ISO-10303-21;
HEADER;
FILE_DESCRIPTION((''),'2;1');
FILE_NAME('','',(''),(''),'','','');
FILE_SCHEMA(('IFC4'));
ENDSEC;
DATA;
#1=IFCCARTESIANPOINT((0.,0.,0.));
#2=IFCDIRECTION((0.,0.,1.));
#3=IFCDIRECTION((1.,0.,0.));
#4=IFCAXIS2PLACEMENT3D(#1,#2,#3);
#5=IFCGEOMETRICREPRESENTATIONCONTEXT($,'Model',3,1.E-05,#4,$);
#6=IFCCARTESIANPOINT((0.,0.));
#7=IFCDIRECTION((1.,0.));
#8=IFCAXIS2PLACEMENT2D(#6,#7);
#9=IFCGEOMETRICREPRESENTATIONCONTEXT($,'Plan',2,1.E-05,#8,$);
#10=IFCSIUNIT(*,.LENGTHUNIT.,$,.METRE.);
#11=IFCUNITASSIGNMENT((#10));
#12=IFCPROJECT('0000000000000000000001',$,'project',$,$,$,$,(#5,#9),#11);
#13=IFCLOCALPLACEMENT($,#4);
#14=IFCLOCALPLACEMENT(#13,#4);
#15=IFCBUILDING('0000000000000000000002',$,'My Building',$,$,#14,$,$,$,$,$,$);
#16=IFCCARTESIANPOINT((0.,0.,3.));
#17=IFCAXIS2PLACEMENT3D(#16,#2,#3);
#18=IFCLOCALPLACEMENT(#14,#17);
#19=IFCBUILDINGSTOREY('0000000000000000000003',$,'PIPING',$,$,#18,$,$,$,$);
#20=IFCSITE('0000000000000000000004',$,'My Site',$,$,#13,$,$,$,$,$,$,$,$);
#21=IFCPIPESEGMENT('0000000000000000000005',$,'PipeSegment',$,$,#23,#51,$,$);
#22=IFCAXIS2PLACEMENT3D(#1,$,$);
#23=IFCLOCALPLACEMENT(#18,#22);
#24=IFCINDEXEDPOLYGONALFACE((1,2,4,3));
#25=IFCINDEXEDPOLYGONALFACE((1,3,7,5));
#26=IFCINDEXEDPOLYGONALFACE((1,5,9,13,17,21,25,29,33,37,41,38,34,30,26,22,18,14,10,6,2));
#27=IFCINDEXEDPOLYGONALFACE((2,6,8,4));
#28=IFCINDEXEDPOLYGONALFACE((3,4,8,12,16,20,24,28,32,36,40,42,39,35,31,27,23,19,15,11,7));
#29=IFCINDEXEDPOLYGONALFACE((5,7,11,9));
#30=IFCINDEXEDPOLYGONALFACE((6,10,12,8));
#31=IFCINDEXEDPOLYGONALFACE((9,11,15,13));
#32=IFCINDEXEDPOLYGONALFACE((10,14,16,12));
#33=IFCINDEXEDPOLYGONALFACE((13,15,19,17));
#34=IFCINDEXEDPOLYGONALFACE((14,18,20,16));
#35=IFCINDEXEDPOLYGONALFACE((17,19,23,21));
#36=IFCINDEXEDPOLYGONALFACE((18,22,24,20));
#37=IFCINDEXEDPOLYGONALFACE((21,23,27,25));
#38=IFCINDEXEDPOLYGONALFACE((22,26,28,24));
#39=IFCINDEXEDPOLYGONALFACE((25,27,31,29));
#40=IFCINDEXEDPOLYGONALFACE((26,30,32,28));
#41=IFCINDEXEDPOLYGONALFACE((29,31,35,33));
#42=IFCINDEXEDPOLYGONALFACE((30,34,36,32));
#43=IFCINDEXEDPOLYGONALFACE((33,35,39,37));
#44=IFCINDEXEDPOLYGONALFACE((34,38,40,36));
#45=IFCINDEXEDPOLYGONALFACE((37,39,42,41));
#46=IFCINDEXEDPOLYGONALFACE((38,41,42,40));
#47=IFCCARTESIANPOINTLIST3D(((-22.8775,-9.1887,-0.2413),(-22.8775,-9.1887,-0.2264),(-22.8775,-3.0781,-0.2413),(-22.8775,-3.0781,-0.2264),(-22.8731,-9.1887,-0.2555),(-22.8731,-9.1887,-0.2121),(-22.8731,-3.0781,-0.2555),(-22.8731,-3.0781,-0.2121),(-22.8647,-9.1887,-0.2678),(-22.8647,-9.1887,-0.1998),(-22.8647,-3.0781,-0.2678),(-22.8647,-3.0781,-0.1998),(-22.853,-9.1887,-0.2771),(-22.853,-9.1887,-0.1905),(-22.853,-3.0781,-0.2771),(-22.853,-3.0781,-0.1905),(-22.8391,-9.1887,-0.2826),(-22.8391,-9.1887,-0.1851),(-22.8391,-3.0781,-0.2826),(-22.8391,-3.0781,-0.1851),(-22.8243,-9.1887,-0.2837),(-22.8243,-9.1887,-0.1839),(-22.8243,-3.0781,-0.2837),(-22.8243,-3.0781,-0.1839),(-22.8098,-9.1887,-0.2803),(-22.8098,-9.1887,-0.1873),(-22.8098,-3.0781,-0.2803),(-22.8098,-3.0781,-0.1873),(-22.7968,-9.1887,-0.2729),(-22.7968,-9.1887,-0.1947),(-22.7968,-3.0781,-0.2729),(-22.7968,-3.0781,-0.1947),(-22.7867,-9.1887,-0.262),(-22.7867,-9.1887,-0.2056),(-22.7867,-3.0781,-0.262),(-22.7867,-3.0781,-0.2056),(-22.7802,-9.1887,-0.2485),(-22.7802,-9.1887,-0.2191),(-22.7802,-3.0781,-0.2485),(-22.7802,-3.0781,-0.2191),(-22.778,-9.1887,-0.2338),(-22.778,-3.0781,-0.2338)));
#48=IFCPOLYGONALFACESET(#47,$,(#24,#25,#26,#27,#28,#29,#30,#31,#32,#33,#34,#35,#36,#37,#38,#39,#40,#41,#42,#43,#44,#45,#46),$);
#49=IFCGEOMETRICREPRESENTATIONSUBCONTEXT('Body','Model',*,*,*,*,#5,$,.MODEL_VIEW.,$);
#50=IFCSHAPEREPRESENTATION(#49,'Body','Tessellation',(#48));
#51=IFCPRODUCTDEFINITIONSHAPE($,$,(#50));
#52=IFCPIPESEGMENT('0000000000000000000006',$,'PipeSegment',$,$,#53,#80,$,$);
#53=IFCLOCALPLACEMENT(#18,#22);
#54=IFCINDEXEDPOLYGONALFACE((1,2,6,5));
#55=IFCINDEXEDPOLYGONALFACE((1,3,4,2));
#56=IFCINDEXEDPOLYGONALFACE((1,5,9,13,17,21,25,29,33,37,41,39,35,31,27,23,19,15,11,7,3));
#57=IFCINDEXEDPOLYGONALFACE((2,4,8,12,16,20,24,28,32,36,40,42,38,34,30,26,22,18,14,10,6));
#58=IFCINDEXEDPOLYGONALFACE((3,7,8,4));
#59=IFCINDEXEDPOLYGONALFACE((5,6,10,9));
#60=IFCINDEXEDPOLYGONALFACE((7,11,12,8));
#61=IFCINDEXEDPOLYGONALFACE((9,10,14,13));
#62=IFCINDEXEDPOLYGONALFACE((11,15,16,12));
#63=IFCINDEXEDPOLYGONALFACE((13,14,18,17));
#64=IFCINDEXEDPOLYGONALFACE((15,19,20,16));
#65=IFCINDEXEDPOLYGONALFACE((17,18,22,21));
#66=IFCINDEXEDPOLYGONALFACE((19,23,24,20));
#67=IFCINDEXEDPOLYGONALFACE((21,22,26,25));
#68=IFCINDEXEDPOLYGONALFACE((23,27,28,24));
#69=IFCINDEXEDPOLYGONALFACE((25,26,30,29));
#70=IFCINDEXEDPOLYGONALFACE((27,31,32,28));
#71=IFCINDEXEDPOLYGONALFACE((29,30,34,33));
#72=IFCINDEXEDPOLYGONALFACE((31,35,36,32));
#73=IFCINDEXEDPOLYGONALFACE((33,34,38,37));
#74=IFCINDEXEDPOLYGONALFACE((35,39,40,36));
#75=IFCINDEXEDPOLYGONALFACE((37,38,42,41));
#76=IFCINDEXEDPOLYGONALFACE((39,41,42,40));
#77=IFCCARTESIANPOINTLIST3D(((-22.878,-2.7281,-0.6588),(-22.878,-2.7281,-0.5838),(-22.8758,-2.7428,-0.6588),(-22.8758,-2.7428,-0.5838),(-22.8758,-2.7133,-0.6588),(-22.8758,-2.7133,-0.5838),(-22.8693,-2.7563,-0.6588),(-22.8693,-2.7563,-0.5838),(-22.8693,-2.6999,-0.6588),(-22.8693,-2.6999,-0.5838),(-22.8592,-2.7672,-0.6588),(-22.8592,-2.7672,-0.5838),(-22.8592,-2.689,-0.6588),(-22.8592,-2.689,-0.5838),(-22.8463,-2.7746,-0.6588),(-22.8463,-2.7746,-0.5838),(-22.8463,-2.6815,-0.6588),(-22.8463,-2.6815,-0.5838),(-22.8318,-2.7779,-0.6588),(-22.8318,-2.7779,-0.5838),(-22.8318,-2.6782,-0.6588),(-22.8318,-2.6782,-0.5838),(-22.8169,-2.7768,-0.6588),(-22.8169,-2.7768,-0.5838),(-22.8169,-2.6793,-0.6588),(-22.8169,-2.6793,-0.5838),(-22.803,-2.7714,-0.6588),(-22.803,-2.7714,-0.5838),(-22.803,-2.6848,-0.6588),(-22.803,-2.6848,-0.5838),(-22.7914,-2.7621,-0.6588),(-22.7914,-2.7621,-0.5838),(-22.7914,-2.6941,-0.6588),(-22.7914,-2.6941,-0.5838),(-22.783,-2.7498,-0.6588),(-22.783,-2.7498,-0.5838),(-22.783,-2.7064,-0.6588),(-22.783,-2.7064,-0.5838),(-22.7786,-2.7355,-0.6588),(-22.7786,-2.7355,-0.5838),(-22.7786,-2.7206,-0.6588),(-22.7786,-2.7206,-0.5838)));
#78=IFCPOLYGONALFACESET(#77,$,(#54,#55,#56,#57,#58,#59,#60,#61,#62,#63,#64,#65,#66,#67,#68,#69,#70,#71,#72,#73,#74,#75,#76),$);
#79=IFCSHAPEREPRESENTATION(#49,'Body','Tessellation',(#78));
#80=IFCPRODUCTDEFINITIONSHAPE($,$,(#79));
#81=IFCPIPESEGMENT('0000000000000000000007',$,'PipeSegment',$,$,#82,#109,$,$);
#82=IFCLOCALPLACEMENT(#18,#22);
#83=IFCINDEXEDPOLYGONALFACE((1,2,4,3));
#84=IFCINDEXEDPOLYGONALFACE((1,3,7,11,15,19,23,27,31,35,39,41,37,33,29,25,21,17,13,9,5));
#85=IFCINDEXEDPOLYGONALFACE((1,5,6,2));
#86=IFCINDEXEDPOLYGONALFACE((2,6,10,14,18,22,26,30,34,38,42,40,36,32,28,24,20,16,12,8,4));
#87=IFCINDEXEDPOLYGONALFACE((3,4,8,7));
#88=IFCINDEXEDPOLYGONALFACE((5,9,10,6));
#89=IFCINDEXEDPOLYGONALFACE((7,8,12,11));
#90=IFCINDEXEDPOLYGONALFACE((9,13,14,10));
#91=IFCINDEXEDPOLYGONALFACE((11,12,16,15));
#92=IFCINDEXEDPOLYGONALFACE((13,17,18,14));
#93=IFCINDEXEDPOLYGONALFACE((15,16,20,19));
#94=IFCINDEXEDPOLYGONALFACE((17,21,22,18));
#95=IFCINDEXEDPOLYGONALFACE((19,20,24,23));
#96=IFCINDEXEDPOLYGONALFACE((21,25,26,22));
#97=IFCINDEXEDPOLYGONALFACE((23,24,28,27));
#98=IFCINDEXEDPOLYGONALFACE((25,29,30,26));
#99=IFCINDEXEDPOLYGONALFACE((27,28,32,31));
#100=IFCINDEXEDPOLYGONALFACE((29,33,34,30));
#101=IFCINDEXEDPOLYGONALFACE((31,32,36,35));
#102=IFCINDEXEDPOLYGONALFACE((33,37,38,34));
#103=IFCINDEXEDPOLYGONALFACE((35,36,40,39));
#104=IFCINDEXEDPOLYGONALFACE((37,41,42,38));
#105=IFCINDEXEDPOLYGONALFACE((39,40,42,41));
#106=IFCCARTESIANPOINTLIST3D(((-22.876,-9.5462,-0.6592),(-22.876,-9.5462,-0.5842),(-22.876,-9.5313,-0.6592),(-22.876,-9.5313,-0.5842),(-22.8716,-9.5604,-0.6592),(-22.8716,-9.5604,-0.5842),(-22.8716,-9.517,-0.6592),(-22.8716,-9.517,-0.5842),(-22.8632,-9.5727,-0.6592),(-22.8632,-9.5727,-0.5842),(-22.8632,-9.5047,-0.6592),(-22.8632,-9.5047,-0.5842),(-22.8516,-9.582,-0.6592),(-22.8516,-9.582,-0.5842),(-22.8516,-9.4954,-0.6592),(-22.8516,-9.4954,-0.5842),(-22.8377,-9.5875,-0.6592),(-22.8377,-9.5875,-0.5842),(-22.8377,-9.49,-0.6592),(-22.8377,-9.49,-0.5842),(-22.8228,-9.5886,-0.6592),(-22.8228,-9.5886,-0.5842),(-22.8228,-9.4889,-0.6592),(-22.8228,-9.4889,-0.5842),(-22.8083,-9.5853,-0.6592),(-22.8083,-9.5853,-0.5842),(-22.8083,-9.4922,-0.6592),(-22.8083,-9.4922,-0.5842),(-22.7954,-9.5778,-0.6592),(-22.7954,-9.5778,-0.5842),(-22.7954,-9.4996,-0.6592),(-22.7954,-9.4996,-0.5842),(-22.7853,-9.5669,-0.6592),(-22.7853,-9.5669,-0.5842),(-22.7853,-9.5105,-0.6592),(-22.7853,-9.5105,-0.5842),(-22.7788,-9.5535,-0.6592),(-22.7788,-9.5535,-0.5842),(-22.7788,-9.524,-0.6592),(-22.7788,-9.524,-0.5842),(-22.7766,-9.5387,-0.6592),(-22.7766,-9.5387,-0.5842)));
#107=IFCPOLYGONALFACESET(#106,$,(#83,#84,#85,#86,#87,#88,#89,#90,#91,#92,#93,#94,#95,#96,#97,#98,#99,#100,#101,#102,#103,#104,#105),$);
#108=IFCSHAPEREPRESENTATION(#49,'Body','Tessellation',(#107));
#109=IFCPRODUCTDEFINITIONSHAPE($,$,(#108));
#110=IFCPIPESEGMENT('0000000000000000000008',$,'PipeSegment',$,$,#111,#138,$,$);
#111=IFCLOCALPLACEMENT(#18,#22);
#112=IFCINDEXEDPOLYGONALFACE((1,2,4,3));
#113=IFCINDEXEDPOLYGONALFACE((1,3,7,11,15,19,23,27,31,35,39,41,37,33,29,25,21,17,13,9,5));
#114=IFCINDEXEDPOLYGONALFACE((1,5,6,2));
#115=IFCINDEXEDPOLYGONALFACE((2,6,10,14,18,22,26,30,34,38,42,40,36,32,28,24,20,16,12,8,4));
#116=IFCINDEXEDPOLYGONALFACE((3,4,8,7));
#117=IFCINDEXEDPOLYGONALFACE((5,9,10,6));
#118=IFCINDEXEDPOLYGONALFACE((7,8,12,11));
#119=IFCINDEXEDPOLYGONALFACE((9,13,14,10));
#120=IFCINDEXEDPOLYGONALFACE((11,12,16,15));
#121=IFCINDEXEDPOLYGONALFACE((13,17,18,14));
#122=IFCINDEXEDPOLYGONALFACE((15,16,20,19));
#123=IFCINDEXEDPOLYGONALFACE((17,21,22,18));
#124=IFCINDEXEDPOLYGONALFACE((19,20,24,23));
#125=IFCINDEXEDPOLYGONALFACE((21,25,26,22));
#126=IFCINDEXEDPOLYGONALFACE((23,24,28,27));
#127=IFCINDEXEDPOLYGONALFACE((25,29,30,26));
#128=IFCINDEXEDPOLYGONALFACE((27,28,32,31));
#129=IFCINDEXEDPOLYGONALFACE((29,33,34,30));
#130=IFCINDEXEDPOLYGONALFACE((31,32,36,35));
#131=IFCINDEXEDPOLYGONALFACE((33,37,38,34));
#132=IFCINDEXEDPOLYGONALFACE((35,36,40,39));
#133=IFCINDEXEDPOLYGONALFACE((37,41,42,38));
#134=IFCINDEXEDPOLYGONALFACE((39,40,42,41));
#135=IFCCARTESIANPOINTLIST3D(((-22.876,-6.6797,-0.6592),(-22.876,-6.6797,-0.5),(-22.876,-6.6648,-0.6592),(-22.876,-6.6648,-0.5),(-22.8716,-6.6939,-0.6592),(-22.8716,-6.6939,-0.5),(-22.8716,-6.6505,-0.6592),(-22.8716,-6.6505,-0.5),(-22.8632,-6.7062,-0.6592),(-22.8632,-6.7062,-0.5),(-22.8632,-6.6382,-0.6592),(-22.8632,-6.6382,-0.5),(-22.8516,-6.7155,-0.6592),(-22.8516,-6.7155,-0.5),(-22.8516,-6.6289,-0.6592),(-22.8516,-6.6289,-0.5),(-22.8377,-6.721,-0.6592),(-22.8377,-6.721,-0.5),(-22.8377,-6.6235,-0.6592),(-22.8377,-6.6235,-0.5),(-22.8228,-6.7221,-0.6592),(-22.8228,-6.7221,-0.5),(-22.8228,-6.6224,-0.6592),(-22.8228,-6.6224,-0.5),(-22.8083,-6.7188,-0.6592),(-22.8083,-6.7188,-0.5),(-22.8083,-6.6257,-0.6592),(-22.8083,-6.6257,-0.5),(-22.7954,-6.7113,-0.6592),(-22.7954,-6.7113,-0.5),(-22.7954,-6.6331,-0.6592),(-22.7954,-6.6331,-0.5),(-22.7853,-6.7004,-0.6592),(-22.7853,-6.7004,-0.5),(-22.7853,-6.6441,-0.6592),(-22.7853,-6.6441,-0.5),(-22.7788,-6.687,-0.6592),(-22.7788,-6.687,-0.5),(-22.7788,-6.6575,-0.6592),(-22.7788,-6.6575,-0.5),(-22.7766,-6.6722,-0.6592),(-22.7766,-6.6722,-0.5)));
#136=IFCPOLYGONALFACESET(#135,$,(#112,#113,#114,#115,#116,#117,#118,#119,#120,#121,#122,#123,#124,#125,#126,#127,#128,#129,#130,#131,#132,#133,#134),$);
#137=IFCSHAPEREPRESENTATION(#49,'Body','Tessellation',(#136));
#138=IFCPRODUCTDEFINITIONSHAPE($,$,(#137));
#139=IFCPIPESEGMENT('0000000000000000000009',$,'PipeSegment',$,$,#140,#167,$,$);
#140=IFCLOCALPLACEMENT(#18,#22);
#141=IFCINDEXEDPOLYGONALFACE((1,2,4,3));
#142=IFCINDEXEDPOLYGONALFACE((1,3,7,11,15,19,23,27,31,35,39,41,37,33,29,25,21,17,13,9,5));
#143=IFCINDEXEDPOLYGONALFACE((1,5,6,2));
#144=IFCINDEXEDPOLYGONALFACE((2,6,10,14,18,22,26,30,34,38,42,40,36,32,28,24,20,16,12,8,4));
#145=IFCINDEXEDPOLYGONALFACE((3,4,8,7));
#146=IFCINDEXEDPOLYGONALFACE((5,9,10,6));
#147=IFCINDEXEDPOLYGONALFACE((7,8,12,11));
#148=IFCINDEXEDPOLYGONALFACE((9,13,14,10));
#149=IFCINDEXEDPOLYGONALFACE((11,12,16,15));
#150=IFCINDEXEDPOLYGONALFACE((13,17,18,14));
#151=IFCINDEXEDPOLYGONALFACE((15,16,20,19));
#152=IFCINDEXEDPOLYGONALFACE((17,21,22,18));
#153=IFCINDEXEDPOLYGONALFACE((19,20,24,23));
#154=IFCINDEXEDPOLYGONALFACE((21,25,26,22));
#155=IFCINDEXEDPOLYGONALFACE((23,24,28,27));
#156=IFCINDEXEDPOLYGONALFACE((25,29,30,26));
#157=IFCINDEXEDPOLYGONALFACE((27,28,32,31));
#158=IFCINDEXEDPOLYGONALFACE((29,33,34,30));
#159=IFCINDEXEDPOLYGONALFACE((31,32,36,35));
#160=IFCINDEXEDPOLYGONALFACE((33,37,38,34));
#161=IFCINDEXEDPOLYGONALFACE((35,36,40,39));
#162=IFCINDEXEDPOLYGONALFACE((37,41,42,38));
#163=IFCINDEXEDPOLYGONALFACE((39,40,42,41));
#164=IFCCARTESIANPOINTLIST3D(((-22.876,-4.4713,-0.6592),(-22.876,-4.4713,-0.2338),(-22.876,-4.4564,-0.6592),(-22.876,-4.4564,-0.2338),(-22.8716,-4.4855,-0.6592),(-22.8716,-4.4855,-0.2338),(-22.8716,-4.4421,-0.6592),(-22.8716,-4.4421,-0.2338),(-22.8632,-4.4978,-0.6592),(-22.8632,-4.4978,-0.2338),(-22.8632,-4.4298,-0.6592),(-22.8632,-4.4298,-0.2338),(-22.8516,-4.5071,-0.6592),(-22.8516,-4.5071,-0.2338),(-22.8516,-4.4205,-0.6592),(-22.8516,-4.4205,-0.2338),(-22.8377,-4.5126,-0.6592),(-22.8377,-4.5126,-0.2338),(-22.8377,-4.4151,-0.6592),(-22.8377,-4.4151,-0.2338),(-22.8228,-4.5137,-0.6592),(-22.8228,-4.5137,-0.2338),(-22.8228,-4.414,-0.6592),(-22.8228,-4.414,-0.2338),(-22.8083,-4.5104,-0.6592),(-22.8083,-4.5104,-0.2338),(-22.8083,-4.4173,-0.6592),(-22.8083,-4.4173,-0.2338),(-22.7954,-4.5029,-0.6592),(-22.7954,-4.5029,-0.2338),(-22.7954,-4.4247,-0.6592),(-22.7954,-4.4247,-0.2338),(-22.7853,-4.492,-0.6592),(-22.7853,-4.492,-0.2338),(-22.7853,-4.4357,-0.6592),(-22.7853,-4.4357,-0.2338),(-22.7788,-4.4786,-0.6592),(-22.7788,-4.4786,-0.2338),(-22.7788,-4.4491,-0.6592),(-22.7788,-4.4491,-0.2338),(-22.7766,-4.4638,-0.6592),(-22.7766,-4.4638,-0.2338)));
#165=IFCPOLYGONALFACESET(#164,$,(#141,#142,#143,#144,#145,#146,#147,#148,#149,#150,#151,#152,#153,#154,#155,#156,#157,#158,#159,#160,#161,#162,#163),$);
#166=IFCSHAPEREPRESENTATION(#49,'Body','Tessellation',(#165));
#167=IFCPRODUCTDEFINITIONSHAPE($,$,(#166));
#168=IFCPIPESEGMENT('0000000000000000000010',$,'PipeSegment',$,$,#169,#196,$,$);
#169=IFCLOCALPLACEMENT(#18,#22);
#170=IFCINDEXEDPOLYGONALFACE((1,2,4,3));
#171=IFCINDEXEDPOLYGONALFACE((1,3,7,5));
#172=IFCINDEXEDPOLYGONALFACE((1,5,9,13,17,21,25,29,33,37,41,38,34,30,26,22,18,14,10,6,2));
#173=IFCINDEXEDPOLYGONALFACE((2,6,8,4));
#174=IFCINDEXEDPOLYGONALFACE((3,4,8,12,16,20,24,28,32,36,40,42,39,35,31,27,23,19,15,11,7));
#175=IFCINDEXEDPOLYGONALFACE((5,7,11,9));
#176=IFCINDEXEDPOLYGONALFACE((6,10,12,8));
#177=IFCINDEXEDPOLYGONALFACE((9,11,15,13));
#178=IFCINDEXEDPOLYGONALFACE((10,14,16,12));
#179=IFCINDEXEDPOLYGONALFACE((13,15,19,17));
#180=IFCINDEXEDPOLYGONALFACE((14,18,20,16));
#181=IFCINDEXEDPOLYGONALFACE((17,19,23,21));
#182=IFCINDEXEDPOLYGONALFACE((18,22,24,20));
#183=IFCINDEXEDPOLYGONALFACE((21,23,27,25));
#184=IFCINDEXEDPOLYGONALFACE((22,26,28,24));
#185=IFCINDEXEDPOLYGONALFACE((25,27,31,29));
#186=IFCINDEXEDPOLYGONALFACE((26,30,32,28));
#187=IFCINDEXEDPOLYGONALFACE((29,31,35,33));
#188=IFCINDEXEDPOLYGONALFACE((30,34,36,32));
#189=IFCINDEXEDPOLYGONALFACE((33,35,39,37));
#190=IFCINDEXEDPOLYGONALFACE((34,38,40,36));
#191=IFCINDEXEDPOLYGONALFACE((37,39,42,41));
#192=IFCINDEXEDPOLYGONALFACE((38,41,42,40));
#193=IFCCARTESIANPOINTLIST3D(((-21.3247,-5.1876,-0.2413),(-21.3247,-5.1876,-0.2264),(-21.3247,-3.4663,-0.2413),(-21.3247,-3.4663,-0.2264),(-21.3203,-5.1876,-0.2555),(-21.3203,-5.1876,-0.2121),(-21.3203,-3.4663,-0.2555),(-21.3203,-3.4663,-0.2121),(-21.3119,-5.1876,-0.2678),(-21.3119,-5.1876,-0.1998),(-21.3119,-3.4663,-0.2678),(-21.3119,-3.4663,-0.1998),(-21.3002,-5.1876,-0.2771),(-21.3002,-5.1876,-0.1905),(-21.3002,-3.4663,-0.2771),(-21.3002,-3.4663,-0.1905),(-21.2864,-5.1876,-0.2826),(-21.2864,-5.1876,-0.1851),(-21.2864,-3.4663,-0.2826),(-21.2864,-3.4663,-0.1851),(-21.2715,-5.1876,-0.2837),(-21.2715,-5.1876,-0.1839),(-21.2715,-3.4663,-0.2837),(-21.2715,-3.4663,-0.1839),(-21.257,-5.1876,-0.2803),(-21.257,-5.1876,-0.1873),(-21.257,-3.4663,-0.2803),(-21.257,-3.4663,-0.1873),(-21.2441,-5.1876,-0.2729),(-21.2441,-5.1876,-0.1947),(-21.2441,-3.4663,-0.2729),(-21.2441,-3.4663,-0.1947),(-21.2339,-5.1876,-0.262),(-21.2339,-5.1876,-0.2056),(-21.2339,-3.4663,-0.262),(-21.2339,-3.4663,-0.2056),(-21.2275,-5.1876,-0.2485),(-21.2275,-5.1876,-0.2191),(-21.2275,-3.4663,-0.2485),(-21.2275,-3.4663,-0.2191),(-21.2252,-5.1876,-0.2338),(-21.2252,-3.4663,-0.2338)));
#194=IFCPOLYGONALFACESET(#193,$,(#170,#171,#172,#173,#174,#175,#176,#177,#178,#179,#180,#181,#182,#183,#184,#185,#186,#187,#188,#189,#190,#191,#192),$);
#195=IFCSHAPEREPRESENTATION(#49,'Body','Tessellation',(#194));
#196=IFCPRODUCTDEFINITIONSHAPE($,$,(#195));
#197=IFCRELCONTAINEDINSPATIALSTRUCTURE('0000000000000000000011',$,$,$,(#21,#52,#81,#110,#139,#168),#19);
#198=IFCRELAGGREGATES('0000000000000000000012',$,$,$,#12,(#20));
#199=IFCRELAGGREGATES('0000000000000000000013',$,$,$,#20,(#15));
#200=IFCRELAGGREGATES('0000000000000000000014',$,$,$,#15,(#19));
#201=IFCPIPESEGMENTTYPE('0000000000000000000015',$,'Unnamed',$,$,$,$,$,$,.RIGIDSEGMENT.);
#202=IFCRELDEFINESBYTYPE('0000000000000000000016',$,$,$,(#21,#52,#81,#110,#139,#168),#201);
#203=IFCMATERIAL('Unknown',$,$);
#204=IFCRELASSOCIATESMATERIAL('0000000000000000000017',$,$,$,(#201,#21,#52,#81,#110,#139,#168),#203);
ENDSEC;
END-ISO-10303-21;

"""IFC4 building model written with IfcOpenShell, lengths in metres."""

from ifc_helpers import new_model, si_unit, frame, origin_with_axes, origin_2d_with_axis, place, context, subcontext, project, spatial, circle, extrude, material, material_profile, profile_set, profile_usage, type_object, element, save


model = new_model("IFC4")

# Units and contexts
model_context = context("Model", 3, precision=1e-05, world=origin_with_axes())
plan_context = context("Plan", 2, precision=1e-05, world=origin_2d_with_axis())
body_context = subcontext(model_context, "Body", "Model", "MODEL_VIEW")
ifc_project = project(units=[si_unit("LENGTHUNIT", "METRE")], contexts=[model_context, plan_context])

# Site, building, storey
site_placement = place(None, origin_with_axes())
site = spatial("IfcSite", under=ifc_project, at=site_placement, Name="My Site")
building_placement = place(site_placement, origin_with_axes())
building = spatial("IfcBuilding", under=site, at=building_placement, Name="My Building")
storey_placement = place(building_placement, frame((0.0, 0.0, 3.0), z_axis=(0.0, 0.0, 1.0), x_axis=(1.0, 0.0, 0.0)))
storey = spatial("IfcBuildingStorey", under=building, at=storey_placement, Name="PIPING")

# Pipe segments
ifc_material = material(Name="Unknown")
ifc_material_profile = material_profile(ifc_material, circle(Radius=0.05))
ifc_profile_set = profile_set([ifc_material_profile])
ifc_profile_usage_1 = profile_usage(ifc_profile_set, cardinal=5)
pipe_segment_type = type_object("IfcPipeSegmentType", Name="Unnamed", PredefinedType="RIGIDSEGMENT", material=ifc_profile_set)
pipe_segment_1_placement = place(storey_placement, frame((-22.828, -3.0781, -0.2338), z_axis=(0.0, -1.0, 0.0), x_axis=(1.0, 0.0, 0.0)))
element("IfcPipeSegment", 1, at=pipe_segment_1_placement, inside=storey, type_object=pipe_segment_type, material=ifc_profile_usage_1, Name="PipeSegment", context=body_context, shape_type="SweptSolid", body=[
    extrude(circle(Radius=0.05), origin_with_axes(), (0.0, 0.0, 1.0), 6.1106),
])
ifc_profile_usage_2 = profile_usage(ifc_profile_set, cardinal=5)
pipe_segment_2_placement = place(storey_placement, frame((-22.828, -2.7281, -0.5838), z_axis=(0.0, 0.0, -1.0), x_axis=(-1.0, 0.0, 0.0)))
element("IfcPipeSegment", 2, at=pipe_segment_2_placement, inside=storey, type_object=pipe_segment_type, material=ifc_profile_usage_2, Name="PipeSegment", context=body_context, shape_type="SweptSolid", body=[
    extrude(circle(Radius=0.05), origin_with_axes(), (0.0, 0.0, 1.0), 0.075),
])
ifc_profile_usage_3 = profile_usage(ifc_profile_set, cardinal=5)
pipe_segment_3_placement = place(storey_placement, frame((-22.8266, -9.5387, -0.5842), z_axis=(0.0, 0.0, -1.0), x_axis=(1.0, 0.0, 0.0)))
element("IfcPipeSegment", 3, at=pipe_segment_3_placement, inside=storey, type_object=pipe_segment_type, material=ifc_profile_usage_3, Name="PipeSegment", context=body_context, shape_type="SweptSolid", body=[
    extrude(circle(Radius=0.05), origin_with_axes(), (0.0, 0.0, 1.0), 0.075),
])
ifc_profile_usage_4 = profile_usage(ifc_profile_set, cardinal=5)
pipe_segment_4_placement = place(storey_placement, frame((-22.8266, -6.6722, -0.5), z_axis=(0.0, 0.0, -1.0), x_axis=(1.0, 0.0, 0.0)))
element("IfcPipeSegment", 4, at=pipe_segment_4_placement, inside=storey, type_object=pipe_segment_type, material=ifc_profile_usage_4, Name="PipeSegment", context=body_context, shape_type="SweptSolid", body=[
    extrude(circle(Radius=0.05), origin_with_axes(), (0.0, 0.0, 1.0), 0.1592),
])
ifc_profile_usage_5 = profile_usage(ifc_profile_set, cardinal=5)
pipe_segment_5_placement = place(storey_placement, frame((-22.8266, -4.4638, -0.2338), z_axis=(0.0, 0.0, -1.0), x_axis=(1.0, 0.0, 0.0)))
element("IfcPipeSegment", 5, at=pipe_segment_5_placement, inside=storey, type_object=pipe_segment_type, material=ifc_profile_usage_5, Name="PipeSegment", context=body_context, shape_type="SweptSolid", body=[
    extrude(circle(Radius=0.05), origin_with_axes(), (0.0, 0.0, 1.0), 0.4254),
])
ifc_profile_usage_6 = profile_usage(ifc_profile_set, cardinal=5)
pipe_segment_6_placement = place(storey_placement, frame((-21.2752, -3.4663, -0.2338), z_axis=(0.0, -1.0, 0.0), x_axis=(1.0, 0.0, 0.0)))
element("IfcPipeSegment", 6, at=pipe_segment_6_placement, inside=storey, type_object=pipe_segment_type, material=ifc_profile_usage_6, Name="PipeSegment", context=body_context, shape_type="SweptSolid", body=[
    extrude(circle(Radius=0.05), origin_with_axes(), (0.0, 0.0, 1.0), 1.7213),
])

save(model, "model.ifc")
